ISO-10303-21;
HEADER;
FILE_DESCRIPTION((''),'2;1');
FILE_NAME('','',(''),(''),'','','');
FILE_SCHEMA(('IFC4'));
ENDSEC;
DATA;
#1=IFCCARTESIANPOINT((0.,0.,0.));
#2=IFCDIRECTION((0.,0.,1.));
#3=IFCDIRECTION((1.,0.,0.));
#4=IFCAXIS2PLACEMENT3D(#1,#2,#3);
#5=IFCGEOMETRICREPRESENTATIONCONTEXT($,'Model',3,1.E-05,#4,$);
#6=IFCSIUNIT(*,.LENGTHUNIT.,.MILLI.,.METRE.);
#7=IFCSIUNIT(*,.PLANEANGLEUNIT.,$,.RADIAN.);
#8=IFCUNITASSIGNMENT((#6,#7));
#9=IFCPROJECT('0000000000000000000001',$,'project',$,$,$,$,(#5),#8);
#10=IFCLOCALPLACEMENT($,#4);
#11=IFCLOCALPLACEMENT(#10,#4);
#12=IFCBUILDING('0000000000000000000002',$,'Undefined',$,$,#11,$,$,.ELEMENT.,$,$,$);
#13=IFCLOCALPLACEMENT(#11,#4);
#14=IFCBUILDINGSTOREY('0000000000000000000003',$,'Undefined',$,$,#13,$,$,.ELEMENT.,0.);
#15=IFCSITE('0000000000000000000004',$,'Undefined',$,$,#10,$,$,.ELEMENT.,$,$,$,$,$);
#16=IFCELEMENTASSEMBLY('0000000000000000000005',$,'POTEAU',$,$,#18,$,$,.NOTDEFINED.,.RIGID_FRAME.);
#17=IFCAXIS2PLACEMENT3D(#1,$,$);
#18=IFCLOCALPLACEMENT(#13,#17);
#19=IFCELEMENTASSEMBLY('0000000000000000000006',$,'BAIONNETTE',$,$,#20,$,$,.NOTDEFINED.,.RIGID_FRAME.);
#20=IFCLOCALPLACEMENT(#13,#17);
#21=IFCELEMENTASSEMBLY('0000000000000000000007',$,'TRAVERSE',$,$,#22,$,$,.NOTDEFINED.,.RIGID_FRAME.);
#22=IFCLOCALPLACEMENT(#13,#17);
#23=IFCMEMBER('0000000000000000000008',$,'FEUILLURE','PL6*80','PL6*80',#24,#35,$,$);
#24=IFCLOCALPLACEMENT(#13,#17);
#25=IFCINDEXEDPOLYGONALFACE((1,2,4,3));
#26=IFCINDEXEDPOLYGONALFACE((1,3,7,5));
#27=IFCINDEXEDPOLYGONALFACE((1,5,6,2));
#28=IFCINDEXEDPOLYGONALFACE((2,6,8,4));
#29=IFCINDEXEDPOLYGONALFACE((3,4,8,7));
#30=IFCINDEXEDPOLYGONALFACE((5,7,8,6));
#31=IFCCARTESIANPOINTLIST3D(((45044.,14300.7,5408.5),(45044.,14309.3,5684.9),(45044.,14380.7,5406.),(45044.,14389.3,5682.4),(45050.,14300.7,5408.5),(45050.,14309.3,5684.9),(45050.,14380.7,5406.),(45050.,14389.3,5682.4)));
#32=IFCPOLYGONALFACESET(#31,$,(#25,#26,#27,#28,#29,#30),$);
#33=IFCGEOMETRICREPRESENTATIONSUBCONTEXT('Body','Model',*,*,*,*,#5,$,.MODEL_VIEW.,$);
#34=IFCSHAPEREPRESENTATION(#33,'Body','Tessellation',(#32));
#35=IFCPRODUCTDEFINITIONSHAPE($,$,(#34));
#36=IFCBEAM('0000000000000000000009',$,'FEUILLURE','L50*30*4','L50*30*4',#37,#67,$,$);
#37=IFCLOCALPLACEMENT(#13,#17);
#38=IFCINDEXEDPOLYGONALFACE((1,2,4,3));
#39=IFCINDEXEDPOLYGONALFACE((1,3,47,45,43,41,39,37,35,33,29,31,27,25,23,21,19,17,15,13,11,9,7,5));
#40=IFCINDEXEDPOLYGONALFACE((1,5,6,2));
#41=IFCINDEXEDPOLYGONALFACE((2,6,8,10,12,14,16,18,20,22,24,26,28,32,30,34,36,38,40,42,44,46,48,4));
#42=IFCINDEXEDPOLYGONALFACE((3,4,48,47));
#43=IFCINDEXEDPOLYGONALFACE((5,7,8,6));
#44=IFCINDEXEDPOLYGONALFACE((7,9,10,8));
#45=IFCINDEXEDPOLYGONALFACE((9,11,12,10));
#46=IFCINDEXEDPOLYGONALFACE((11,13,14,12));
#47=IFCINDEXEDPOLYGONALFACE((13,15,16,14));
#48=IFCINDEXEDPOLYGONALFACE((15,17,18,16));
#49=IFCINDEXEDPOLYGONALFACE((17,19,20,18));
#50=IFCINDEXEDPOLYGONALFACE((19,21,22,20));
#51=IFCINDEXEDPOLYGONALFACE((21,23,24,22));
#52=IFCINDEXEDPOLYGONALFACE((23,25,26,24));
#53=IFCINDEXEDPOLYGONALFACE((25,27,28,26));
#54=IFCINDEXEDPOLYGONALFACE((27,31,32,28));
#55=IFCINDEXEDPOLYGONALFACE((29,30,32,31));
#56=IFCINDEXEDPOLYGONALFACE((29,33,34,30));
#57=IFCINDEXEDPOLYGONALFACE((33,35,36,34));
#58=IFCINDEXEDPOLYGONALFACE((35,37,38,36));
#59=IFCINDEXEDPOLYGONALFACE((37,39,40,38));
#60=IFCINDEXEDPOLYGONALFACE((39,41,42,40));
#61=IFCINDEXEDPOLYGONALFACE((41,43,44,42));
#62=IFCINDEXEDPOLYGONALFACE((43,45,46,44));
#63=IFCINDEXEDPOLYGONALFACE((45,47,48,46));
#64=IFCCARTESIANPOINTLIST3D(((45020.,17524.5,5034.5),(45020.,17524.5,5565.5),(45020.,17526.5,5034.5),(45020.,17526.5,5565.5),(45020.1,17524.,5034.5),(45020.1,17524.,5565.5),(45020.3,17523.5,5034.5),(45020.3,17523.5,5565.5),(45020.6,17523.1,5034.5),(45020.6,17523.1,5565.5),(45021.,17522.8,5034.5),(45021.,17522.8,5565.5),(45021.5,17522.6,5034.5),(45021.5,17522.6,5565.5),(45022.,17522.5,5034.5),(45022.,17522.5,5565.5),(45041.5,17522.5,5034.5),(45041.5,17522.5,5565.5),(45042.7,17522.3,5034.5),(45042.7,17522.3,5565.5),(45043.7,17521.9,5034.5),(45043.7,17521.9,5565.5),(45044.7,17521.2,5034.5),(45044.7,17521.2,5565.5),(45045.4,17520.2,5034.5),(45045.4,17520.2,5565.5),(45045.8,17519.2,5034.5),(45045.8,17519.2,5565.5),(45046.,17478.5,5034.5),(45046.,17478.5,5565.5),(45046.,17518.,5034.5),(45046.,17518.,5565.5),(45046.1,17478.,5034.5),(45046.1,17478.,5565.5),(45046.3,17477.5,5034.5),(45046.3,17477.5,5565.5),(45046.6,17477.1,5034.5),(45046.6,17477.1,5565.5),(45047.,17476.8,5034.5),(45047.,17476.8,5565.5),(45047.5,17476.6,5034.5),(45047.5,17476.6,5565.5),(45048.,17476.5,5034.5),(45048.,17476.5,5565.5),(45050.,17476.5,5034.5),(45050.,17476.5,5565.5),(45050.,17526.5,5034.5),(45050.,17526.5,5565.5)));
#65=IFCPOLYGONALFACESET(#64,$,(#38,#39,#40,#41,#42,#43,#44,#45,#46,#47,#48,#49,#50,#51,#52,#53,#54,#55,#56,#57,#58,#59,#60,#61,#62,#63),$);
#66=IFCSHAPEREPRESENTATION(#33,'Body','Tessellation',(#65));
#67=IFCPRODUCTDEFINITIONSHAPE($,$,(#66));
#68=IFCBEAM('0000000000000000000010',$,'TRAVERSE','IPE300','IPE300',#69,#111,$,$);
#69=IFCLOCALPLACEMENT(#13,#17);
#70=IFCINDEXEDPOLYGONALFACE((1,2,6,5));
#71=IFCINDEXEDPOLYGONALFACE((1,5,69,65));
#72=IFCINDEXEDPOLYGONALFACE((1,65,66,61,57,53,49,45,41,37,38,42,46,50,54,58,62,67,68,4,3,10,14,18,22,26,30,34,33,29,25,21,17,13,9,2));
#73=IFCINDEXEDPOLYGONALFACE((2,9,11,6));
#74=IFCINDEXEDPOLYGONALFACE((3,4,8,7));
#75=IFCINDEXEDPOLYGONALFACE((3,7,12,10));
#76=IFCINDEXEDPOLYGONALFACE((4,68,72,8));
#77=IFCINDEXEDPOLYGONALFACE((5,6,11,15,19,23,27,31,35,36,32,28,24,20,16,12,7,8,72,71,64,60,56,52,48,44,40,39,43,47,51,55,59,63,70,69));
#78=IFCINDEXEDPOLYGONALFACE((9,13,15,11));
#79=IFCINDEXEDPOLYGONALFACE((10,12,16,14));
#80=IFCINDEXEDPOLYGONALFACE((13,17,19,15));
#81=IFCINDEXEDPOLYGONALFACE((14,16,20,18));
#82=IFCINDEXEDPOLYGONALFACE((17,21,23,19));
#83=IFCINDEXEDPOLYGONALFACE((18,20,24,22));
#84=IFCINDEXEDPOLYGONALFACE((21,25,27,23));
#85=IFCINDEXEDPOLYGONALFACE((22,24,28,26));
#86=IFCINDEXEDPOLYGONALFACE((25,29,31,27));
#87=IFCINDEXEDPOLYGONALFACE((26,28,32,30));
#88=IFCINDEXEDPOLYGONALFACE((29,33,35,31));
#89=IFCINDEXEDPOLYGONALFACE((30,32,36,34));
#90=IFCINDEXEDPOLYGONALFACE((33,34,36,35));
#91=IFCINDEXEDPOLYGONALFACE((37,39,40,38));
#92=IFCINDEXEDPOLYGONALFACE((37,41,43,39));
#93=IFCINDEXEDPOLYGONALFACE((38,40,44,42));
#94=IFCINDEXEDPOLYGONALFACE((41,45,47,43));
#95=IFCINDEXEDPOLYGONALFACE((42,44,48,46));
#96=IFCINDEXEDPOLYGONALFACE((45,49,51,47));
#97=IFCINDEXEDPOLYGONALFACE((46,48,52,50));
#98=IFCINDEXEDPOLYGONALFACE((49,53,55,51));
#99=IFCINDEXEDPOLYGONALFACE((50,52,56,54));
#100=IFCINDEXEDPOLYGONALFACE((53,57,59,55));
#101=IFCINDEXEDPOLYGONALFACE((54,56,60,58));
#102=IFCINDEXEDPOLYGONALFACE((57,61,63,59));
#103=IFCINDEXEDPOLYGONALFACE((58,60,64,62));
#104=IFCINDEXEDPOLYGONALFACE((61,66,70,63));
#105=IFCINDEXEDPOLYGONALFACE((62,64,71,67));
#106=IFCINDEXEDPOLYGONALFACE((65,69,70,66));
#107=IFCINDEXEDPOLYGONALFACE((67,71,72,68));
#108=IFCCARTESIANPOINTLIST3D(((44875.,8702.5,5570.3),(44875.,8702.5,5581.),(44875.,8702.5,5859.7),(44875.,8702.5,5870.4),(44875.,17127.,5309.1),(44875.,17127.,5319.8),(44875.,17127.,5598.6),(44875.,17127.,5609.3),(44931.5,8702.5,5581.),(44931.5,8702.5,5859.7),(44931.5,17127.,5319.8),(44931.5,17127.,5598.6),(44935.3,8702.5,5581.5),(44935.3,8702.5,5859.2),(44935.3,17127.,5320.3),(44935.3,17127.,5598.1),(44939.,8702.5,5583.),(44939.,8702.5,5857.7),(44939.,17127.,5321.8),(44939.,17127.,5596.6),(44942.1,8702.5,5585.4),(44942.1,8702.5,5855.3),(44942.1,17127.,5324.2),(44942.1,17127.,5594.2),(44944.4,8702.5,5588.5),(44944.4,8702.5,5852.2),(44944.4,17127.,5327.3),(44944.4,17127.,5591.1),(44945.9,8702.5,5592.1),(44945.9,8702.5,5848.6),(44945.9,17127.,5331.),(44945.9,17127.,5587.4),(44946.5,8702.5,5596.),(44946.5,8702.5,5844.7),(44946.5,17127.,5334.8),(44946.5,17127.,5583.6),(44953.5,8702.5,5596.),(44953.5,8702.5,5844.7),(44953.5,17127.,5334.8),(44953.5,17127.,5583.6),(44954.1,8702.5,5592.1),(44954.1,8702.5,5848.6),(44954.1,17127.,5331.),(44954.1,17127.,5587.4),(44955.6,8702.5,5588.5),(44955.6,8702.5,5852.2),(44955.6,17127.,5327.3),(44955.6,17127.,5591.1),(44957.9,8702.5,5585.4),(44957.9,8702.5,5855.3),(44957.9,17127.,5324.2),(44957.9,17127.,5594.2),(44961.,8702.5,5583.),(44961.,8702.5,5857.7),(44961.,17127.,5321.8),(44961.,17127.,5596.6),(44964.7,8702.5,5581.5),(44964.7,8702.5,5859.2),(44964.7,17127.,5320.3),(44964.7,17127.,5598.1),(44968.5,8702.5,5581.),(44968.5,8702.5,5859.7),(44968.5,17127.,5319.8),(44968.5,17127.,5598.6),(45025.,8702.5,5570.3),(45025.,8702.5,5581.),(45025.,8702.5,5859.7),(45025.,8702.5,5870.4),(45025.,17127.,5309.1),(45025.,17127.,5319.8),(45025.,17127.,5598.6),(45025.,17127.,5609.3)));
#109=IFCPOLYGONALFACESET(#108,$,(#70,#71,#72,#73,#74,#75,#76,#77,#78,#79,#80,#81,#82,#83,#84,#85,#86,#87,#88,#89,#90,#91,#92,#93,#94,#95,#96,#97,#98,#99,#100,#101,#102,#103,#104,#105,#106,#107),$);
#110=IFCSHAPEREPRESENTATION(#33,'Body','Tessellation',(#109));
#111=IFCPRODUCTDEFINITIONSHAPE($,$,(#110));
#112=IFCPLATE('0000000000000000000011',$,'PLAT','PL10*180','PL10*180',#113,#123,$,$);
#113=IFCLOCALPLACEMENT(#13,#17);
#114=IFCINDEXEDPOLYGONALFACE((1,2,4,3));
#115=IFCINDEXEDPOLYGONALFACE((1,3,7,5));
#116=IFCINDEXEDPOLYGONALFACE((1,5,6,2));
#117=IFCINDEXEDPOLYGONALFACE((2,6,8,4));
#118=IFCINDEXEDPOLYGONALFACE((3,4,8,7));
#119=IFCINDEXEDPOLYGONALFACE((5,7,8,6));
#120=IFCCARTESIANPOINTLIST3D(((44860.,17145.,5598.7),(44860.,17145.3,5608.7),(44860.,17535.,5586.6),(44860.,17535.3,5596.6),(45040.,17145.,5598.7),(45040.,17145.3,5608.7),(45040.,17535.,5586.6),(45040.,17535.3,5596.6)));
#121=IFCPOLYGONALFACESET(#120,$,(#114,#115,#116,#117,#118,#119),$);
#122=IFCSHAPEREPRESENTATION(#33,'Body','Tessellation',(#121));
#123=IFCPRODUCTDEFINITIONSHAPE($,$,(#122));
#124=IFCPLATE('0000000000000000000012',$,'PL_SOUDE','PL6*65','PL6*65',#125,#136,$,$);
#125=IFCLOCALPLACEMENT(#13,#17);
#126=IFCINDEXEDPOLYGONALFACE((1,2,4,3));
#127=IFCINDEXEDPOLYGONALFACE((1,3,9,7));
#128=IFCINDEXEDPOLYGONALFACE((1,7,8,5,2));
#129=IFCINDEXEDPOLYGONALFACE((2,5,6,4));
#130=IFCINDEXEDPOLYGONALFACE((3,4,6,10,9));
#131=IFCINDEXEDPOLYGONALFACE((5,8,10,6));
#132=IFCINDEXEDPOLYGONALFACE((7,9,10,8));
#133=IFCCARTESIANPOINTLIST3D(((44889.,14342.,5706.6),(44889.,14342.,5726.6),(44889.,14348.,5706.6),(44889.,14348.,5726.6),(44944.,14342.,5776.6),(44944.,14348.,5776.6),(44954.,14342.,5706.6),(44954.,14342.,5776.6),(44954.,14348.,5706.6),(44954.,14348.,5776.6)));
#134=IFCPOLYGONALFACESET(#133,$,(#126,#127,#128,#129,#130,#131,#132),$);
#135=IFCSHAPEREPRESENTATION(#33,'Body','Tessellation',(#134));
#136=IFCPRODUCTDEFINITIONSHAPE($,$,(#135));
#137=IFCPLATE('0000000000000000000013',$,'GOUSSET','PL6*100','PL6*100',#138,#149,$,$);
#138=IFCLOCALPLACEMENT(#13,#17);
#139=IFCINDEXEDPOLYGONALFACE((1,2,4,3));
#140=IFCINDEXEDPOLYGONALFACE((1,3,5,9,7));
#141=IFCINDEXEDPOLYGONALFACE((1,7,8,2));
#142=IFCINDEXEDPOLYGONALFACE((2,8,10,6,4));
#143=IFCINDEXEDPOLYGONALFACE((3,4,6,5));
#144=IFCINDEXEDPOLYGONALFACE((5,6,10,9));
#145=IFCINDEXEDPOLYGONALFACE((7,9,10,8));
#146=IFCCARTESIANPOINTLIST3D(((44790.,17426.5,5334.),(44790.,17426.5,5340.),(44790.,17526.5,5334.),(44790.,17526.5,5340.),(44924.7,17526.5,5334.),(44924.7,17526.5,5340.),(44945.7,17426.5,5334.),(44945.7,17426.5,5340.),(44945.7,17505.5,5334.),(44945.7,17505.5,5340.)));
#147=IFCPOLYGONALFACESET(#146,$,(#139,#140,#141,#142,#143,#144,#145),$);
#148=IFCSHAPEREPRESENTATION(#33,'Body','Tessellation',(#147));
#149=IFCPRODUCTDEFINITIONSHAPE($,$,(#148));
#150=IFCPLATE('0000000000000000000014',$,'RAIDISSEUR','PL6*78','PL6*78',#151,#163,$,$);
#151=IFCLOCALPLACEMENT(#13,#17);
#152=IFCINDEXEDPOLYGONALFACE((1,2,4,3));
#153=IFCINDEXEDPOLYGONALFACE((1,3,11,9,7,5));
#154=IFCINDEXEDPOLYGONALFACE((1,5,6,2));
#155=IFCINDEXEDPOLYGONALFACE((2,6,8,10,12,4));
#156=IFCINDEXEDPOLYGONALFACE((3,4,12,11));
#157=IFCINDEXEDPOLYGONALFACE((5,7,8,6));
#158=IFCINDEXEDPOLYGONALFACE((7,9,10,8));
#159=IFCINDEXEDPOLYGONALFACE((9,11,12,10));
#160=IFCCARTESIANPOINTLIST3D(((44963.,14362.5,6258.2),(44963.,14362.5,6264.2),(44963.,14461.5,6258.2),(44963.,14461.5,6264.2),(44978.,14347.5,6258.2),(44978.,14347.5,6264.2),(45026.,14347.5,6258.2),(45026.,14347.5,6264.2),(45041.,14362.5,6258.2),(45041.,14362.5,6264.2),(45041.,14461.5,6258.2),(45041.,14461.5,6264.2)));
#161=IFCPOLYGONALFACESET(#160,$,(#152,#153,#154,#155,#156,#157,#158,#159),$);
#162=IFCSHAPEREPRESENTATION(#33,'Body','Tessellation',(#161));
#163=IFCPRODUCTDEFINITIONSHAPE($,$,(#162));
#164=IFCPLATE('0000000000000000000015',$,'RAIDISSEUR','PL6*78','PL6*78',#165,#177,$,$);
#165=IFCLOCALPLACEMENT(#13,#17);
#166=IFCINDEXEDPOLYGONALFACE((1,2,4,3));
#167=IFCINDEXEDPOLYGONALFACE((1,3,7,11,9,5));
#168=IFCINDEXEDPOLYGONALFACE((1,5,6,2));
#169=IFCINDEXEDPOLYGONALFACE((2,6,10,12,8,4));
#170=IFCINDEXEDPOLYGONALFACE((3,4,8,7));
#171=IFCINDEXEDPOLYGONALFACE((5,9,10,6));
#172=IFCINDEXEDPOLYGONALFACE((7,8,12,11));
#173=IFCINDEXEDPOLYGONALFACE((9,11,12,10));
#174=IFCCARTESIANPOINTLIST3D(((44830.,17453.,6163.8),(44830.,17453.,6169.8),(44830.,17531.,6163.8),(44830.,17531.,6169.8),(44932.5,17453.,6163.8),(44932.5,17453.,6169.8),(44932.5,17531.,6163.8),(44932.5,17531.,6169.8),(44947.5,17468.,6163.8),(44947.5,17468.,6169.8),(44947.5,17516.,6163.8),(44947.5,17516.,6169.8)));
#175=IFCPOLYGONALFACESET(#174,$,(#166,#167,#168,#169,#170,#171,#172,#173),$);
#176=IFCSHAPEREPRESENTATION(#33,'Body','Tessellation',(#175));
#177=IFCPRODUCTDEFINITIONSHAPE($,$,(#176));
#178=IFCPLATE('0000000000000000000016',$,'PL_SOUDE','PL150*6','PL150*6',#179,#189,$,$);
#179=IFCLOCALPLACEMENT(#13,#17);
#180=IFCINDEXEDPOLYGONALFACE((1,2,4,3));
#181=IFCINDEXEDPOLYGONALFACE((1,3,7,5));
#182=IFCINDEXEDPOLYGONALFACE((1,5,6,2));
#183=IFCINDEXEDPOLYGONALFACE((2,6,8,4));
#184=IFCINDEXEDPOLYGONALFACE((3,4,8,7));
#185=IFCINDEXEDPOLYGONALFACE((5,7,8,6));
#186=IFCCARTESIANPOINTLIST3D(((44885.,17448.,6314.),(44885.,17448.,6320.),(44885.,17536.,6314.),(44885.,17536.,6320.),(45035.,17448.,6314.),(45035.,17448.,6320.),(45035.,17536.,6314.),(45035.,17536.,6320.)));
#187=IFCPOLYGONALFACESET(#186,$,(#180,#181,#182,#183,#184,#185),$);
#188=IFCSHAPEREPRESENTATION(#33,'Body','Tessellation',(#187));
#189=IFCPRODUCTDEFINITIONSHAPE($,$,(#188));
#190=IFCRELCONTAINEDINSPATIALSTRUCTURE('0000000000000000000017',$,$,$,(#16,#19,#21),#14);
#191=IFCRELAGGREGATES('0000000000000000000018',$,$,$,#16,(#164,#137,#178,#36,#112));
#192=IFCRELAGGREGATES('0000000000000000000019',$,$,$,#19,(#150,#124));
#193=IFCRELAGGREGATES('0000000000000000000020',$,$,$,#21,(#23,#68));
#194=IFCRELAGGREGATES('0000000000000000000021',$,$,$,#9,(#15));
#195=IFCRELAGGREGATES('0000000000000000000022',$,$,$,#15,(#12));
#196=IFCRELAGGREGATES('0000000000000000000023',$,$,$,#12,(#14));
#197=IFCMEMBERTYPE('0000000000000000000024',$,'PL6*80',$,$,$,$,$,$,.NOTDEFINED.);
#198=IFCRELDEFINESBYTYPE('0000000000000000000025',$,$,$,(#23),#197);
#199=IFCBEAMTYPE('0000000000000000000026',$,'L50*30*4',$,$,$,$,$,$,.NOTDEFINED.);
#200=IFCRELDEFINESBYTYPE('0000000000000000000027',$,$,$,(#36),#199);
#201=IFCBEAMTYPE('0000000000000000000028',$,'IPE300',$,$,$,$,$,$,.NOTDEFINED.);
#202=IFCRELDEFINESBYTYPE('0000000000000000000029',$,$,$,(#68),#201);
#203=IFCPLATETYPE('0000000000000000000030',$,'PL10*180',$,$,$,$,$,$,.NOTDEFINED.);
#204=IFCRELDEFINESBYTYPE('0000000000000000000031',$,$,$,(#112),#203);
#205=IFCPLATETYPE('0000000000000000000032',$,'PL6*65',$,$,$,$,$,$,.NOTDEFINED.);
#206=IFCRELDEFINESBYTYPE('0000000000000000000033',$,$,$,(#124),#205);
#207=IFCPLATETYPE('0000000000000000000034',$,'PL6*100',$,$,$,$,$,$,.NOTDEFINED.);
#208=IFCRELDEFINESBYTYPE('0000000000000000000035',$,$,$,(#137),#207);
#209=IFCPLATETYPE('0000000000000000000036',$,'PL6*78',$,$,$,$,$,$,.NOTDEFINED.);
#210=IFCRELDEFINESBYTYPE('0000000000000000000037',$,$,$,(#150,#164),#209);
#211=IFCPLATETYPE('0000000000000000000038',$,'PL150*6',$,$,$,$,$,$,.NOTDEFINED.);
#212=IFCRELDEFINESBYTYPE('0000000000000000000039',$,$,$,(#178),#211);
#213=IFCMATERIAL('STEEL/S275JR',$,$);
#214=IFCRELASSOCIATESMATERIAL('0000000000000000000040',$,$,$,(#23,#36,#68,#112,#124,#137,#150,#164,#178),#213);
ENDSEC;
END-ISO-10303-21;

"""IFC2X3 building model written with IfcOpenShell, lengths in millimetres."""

from ifc_helpers import new_model, si_unit, frame, origin_with_axes, origin_2d_with_axis, place, context, subcontext, project, spatial, polyline, rectangle, i_section, l_section, outline, extrude, clip, halfspace, material, type_object, element, aggregate, save


model = new_model("IFC2X3")

# Units and contexts
model_context = context("Model", 3, precision=1e-05, world=origin_with_axes())
body_context = subcontext(model_context, "Body", "Model", "MODEL_VIEW")
ifc_project = project(units=[si_unit("LENGTHUNIT", "METRE", prefix="MILLI"), si_unit("PLANEANGLEUNIT", "RADIAN")], contexts=[model_context])

# Site, building, storey
site_placement = place(None, origin_with_axes())
site = spatial("IfcSite", under=ifc_project, at=site_placement, Name="Undefined", CompositionType="ELEMENT")
building_placement = place(site_placement, origin_with_axes())
building = spatial("IfcBuilding", under=site, at=building_placement, Name="Undefined", CompositionType="ELEMENT")
storey_placement = place(building_placement, origin_with_axes())
storey = spatial("IfcBuildingStorey", under=building, at=storey_placement, Name="Undefined", CompositionType="ELEMENT", Elevation=0.0)

# Element assembly
assembly_1_placement = place(storey_placement, origin_with_axes())
assembly_1 = element("IfcElementAssembly", 1, at=assembly_1_placement, inside=storey, Name="POTEAU", AssemblyPlace="NOTDEFINED", PredefinedType="RIGID_FRAME")
ifc_material_1 = material(Name="STEEL/S275JR")

# Element assembly
assembly_2_placement = place(storey_placement, origin_with_axes())
assembly_2 = element("IfcElementAssembly", 2, at=assembly_2_placement, inside=storey, Name="BAIONNETTE", AssemblyPlace="NOTDEFINED", PredefinedType="RIGID_FRAME")

# Element assembly, member
assembly_3_placement = place(storey_placement, origin_with_axes())
assembly_3 = element("IfcElementAssembly", 3, at=assembly_3_placement, inside=storey, Name="TRAVERSE", AssemblyPlace="NOTDEFINED", PredefinedType="RIGID_FRAME")
member_type = type_object("IfcMemberType", Name="PL6*80", PredefinedType="NOTDEFINED")
member_placement = place(assembly_3_placement, frame((45047.0, 14349.3, 5683.7), z_axis=(0.0, 0.99952, -0.030986), x_axis=(0.0, -0.030986, -0.99952)))
member = element("IfcMember", 4, at=member_placement, type_object=member_type, material=ifc_material_1, Name="FEUILLURE", Description="PL6*80", ObjectType="PL6*80", context=body_context, shape_type="SweptSolid", body=[
    extrude(rectangle(XDim=6.0, YDim=80.0, at=origin_2d_with_axis()), frame((276.6, 0.0, 0.0), z_axis=(-1.0, 0.0, 0.0), x_axis=(0.0, -1.0, 0.0)), (0.0, 0.0, 1.0), 276.6),
])

# Beams
beam_type_1 = type_object("IfcBeamType", Name="L50*30*4", PredefinedType="NOTDEFINED")
beam_1_placement = place(assembly_1_placement, frame((45035.0, 17501.5, 5565.5), z_axis=(0.0, -1.0, 0.0), x_axis=(0.0, 0.0, -1.0)))
beam_1 = element("IfcBeam", 5, at=beam_1_placement, type_object=beam_type_1, material=ifc_material_1, Name="FEUILLURE", Description="L50*30*4", ObjectType="L50*30*4", context=body_context, shape_type="SweptSolid", body=[
    extrude(l_section(Depth=50.0, Width=30.0, Thickness=4.0, FilletRadius=4.5, EdgeRadius=2.0, at=origin_2d_with_axis()), frame((531.0, 0.0, 0.0), z_axis=(-1.0, 0.0, 0.0), x_axis=(0.0, -1.0, 0.0)), (0.0, 0.0, 1.0), 531.0),
])
beam_type_2 = type_object("IfcBeamType", Name="IPE300", PredefinedType="NOTDEFINED")
beam_2_placement = place(assembly_3_placement, frame((44950.0, 17375.4, 5451.5), z_axis=(0.0, 0.030986, 0.99952), x_axis=(0.0, -0.99952, 0.030986)))
beam_2 = element("IfcBeam", 6, at=beam_2_placement, type_object=beam_type_2, material=ifc_material_1, Name="TRAVERSE", Description="IPE300", ObjectType="IPE300", context=body_context, shape_type="Clipping", body=[
    clip(clip(extrude(i_section(OverallWidth=150.0, OverallDepth=300.0, WebThickness=7.1, FlangeThickness=10.7, FilletRadius=15.0, at=origin_2d_with_axis()), frame((8686.4, 0.0, 0.0), z_axis=(-1.0, 0.0, 0.0), x_axis=(0.0, -1.0, 0.0)), (0.0, 0.0, 1.0), 8447.3), halfspace(frame((8672.4, 0.0, -150.0), z_axis=(-0.99952, 0.0, 0.030986), x_axis=(0.0, 1.0, 0.0)), True)), halfspace(frame((243.8, 0.0, -150.0), z_axis=(0.99952, 0.0, -0.030986), x_axis=(0.0, -1.0, 0.0)), True)),
])

# Plates
plate_type_1 = type_object("IfcPlateType", Name="PL10*180", PredefinedType="NOTDEFINED")
plate_1_placement = place(assembly_1_placement, frame((44950.0, 17535.2, 5591.6), z_axis=(0.0, -0.030986, -0.99952), x_axis=(0.0, -0.99952, 0.030986)))
plate_1 = element("IfcPlate", 7, at=plate_1_placement, type_object=plate_type_1, material=ifc_material_1, Name="PLAT", Description="PL10*180", ObjectType="PL10*180", context=body_context, shape_type="SweptSolid", body=[
    extrude(outline(polyline([(390.2, 90.0), (390.2, -90.0), (0.0, -90.0), (0.0, 90.0), (390.2, 90.0)])), frame((0.0, 0.0, -5.0), z_axis=(0.0, 0.0, 1.0), x_axis=(1.0, 0.0, 0.0)), (0.0, 0.0, 1.0), 10.0),
])
plate_type_2 = type_object("IfcPlateType", Name="PL6*65", PredefinedType="NOTDEFINED")
plate_2_placement = place(assembly_2_placement, frame((44954.0, 14345.0, 5706.6), z_axis=(0.0, 1.0, 0.0), x_axis=(-1.0, 0.0, 0.0)))
plate_2 = element("IfcPlate", 8, at=plate_2_placement, type_object=plate_type_2, material=ifc_material_1, Name="PL_SOUDE", Description="PL6*65", ObjectType="PL6*65", context=body_context, shape_type="SweptSolid", body=[
    extrude(outline(polyline([(0.0, 0.0), (65.0, 0.0), (65.0, 20.0), (10.0, 70.0), (0.0, 70.0), (0.0, 0.0)])), frame((0.0, 0.0, -3.0), z_axis=(0.0, 0.0, 1.0), x_axis=(1.0, 0.0, 0.0)), (0.0, 0.0, 1.0), 6.0),
])
plate_type_3 = type_object("IfcPlateType", Name="PL6*100", PredefinedType="NOTDEFINED")
plate_3_placement = place(assembly_1_placement, frame((44945.7, 17526.5, 5337.0), z_axis=(0.0, 0.0, 1.0), x_axis=(-1.0, 0.0, 0.0)))
plate_3 = element("IfcPlate", 9, at=plate_3_placement, type_object=plate_type_3, material=ifc_material_1, Name="GOUSSET", Description="PL6*100", ObjectType="PL6*100", context=body_context, shape_type="SweptSolid", body=[
    extrude(outline(polyline([(0.0, 21.0), (21.0, 0.0), (155.7, 0.0), (155.7, 100.0), (0.0, 100.0), (0.0, 21.0)])), frame((0.0, 0.0, -3.0), z_axis=(0.0, 0.0, 1.0), x_axis=(1.0, 0.0, 0.0)), (0.0, 0.0, 1.0), 6.0),
])
plate_type_4 = type_object("IfcPlateType", Name="PL6*78", PredefinedType="NOTDEFINED")
plate_4_placement = place(assembly_2_placement, frame((44963.0, 14347.5, 6261.2), z_axis=(0.0, 0.0, -1.0), x_axis=(0.0, 1.0, 0.0)))
plate_4 = element("IfcPlate", 10, at=plate_4_placement, type_object=plate_type_4, material=ifc_material_1, Name="RAIDISSEUR", Description="PL6*78", ObjectType="PL6*78", context=body_context, shape_type="SweptSolid", body=[
    extrude(outline(polyline([(0.0, 15.0), (15.0, 0.0), (114.0, 0.0), (114.0, 78.0), (15.0, 78.0), (0.0, 63.0), (0.0, 15.0)])), frame((0.0, 0.0, -3.0), z_axis=(0.0, 0.0, 1.0), x_axis=(1.0, 0.0, 0.0)), (0.0, 0.0, 1.0), 6.0),
])
plate_5_placement = place(assembly_1_placement, frame((44947.5, 17531.0, 6166.8), z_axis=(0.0, 0.0, 1.0), x_axis=(-1.0, 0.0, 0.0)))
plate_5 = element("IfcPlate", 11, at=plate_5_placement, type_object=plate_type_4, material=ifc_material_1, Name="RAIDISSEUR", Description="PL6*78", ObjectType="PL6*78", context=body_context, shape_type="SweptSolid", body=[
    extrude(outline(polyline([(0.0, 15.0), (15.0, 0.0), (117.5, 0.0), (117.5, 78.0), (15.0, 78.0), (0.0, 63.0), (0.0, 15.0)])), frame((0.0, 0.0, -3.0), z_axis=(0.0, 0.0, 1.0), x_axis=(1.0, 0.0, 0.0)), (0.0, 0.0, 1.0), 6.0),
])
plate_type_5 = type_object("IfcPlateType", Name="PL150*6", PredefinedType="NOTDEFINED")
plate_6_placement = place(assembly_1_placement, frame((44960.0, 17536.0, 6317.0), z_axis=(0.0, 0.0, -1.0), x_axis=(0.0, -1.0, 0.0)))
plate_6 = element("IfcPlate", 12, at=plate_6_placement, type_object=plate_type_5, material=ifc_material_1, Name="PL_SOUDE", Description="PL150*6", ObjectType="PL150*6", context=body_context, shape_type="SweptSolid", body=[
    extrude(outline(polyline([(88.0, 75.0), (88.0, -75.0), (0.0, -75.0), (0.0, 75.0), (88.0, 75.0)])), frame((0.0, 0.0, -3.0), z_axis=(0.0, 0.0, 1.0), x_axis=(1.0, 0.0, 0.0)), (0.0, 0.0, 1.0), 6.0),
])

aggregate(assembly_1, [plate_5, plate_3, plate_6, beam_1, plate_1])

aggregate(assembly_2, [plate_4, plate_2])

aggregate(assembly_3, [member, beam_2])

save(model, "model.ifc")
